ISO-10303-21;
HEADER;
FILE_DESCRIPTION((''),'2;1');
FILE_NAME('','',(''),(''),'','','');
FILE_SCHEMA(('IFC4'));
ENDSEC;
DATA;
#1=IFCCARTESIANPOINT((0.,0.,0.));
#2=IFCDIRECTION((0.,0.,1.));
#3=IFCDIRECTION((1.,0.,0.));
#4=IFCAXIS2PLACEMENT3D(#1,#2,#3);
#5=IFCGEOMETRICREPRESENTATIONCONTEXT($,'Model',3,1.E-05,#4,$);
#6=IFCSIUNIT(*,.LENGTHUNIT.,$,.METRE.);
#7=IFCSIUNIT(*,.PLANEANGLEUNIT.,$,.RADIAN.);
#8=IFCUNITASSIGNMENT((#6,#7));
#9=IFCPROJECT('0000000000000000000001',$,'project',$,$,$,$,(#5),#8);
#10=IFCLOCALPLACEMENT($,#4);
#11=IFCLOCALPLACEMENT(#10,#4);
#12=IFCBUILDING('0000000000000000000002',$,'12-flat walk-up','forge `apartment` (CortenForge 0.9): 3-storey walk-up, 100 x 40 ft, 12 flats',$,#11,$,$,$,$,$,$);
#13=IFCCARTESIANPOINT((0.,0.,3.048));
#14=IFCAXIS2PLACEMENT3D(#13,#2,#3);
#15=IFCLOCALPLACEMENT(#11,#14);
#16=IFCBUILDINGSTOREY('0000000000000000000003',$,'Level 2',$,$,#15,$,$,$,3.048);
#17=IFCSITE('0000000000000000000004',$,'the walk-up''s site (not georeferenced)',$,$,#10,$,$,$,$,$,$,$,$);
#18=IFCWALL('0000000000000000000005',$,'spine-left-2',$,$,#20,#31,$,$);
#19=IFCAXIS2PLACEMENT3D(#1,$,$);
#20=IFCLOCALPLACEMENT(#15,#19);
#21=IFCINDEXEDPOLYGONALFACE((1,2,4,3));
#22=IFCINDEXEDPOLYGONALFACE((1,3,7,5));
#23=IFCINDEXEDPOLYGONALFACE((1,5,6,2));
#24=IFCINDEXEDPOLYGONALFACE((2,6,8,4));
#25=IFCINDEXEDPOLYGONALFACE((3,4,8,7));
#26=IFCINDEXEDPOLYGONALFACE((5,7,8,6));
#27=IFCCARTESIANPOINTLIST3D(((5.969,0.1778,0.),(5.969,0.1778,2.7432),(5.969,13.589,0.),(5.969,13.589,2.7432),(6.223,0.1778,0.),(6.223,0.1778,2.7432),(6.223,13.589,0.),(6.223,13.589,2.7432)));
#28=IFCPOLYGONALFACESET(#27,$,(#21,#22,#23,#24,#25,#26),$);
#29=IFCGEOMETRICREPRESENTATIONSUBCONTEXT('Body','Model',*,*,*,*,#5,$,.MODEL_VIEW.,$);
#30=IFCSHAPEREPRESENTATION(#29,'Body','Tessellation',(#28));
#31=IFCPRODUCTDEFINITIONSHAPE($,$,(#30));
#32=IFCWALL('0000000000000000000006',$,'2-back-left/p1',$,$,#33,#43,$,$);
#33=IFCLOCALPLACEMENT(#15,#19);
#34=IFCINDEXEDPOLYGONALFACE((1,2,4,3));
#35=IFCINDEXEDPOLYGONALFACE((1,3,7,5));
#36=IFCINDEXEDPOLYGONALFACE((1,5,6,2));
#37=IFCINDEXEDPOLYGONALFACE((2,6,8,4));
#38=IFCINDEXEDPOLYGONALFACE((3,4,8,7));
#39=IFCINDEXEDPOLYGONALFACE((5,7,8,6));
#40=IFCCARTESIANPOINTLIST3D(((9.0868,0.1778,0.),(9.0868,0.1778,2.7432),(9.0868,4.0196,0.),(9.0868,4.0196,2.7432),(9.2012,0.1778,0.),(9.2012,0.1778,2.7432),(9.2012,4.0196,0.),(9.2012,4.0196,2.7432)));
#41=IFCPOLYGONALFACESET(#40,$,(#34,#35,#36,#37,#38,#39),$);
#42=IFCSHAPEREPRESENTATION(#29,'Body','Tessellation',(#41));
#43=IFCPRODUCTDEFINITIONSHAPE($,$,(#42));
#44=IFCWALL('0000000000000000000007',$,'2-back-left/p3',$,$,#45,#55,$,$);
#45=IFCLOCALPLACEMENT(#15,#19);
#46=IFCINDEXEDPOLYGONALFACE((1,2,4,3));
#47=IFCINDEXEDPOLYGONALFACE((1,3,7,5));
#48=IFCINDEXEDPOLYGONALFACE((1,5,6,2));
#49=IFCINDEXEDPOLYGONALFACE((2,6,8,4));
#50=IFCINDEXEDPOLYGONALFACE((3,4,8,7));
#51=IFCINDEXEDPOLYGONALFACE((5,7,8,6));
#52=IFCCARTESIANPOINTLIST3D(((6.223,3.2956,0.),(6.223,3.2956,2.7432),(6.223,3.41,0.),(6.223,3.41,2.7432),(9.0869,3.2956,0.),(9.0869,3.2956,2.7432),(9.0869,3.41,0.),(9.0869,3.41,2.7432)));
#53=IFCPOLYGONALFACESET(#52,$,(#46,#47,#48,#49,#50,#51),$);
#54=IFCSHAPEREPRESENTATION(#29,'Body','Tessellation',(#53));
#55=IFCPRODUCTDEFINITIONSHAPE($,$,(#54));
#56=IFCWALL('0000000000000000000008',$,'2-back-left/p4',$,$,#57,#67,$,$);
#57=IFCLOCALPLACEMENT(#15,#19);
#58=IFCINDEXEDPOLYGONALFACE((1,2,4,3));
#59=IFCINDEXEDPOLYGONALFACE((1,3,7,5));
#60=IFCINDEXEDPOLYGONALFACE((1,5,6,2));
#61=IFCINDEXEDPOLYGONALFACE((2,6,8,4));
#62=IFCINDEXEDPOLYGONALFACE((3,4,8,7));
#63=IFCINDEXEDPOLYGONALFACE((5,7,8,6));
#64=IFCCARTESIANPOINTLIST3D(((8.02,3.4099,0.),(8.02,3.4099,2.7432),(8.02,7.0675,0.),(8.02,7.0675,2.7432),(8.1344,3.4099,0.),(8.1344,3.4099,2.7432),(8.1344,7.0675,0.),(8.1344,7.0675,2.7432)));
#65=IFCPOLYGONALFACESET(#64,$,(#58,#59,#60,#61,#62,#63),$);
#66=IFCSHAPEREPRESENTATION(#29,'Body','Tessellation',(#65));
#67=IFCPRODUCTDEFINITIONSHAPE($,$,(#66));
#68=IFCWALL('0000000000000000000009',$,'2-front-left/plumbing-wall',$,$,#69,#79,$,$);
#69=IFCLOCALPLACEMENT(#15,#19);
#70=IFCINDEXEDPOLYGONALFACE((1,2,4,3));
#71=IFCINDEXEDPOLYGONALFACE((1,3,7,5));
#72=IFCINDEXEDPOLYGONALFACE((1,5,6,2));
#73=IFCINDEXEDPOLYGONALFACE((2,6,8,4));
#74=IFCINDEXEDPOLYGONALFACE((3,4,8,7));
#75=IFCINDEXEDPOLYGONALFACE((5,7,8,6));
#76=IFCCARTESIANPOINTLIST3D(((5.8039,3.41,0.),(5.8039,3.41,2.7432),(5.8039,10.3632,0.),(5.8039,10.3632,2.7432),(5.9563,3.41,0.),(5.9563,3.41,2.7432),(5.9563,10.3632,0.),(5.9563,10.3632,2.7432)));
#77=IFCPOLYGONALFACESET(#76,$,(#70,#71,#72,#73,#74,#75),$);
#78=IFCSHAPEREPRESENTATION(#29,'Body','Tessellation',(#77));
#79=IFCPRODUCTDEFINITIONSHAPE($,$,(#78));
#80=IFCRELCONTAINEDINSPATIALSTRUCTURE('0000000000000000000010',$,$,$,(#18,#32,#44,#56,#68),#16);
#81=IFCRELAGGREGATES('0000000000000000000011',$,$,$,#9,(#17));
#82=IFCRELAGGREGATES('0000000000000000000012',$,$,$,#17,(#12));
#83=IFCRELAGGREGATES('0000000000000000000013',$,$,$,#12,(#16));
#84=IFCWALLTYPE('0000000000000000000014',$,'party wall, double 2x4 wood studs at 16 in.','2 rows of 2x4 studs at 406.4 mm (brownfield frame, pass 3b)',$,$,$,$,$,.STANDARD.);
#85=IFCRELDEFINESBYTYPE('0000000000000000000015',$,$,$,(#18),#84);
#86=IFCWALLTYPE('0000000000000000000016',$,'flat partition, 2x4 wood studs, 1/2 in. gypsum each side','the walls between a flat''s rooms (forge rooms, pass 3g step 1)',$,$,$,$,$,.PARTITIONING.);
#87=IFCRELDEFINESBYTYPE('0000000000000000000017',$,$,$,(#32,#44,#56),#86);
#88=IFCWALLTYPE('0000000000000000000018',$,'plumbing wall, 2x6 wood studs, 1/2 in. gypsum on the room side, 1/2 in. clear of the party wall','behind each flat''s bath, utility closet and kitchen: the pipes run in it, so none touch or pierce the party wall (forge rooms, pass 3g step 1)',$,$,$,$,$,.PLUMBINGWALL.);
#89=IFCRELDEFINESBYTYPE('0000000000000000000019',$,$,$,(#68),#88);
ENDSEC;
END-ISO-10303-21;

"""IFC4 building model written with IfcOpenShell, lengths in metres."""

from ifc_helpers import new_model, si_unit, frame, frame_2d, origin, origin_with_axes, place, context, subcontext, project, spatial, rectangle, extrude, type_object, element, save


model = new_model("IFC4")

# Units and contexts
model_context = context("Model", 3, precision=1e-05, world=origin_with_axes())
body_context = subcontext(model_context, "Body", "Model", "MODEL_VIEW")
ifc_project = project(units=[si_unit("LENGTHUNIT", "METRE"), si_unit("PLANEANGLEUNIT", "RADIAN")], contexts=[model_context])

# Site, building, storey
site_placement = place(None, origin_with_axes())
site = spatial("IfcSite", under=ifc_project, at=site_placement, Name="the walk-up's site (not georeferenced)")
building_placement = place(site_placement, origin_with_axes())
building = spatial("IfcBuilding", under=site, at=building_placement, Name="12-flat walk-up", Description="forge `apartment` (CortenForge 0.9): 3-storey walk-up, 100 x 40 ft, 12 flats")
storey_placement = place(building_placement, frame((0.0, 0.0, 3.048), z_axis=(0.0, 0.0, 1.0), x_axis=(1.0, 0.0, 0.0)))
storey = spatial("IfcBuildingStorey", under=building, at=storey_placement, Name="Level 2", Elevation=3.048)

# Walls
wall_type_1 = type_object("IfcWallType", Name="party wall, double 2x4 wood studs at 16 in.", Description="2 rows of 2x4 studs at 406.4 mm (brownfield frame, pass 3b)", PredefinedType="STANDARD")
wall_1_placement = place(storey_placement, frame((5.969, 0.1778, 0.0), z_axis=(0.0, 0.0, 1.0), x_axis=(1.0, 0.0, 0.0)))
element("IfcWall", 1, at=wall_1_placement, inside=storey, type_object=wall_type_1, Name="spine-left-2", context=body_context, shape_type="SweptSolid", body=[
    extrude(rectangle(XDim=0.254, YDim=13.4112, at=frame_2d((0.127, 6.7056))), origin(), (0.0, 0.0, 1.0), 2.7432),
])
wall_type_2 = type_object("IfcWallType", Name="flat partition, 2x4 wood studs, 1/2 in. gypsum each side", Description="the walls between a flat's rooms (forge rooms, pass 3g step 1)", PredefinedType="PARTITIONING")
wall_2_placement = place(storey_placement, frame((9.0869, 0.1778, 0.0), z_axis=(0.0, 0.0, 1.0), x_axis=(1.0, 0.0, 0.0)))
element("IfcWall", 2, at=wall_2_placement, inside=storey, type_object=wall_type_2, Name="2-back-left/p1", context=body_context, shape_type="SweptSolid", body=[
    extrude(rectangle(XDim=0.1143, YDim=3.8417, at=frame_2d((0.0572, 1.9209))), origin(), (0.0, 0.0, 1.0), 2.7432),
])
wall_3_placement = place(storey_placement, frame((6.223, 3.2957, 0.0), z_axis=(0.0, 0.0, 1.0), x_axis=(1.0, 0.0, 0.0)))
element("IfcWall", 3, at=wall_3_placement, inside=storey, type_object=wall_type_2, Name="2-back-left/p3", context=body_context, shape_type="SweptSolid", body=[
    extrude(rectangle(XDim=2.8639, YDim=0.1143, at=frame_2d((1.4319, 0.0571))), origin(), (0.0, 0.0, 1.0), 2.7432),
])
wall_4_placement = place(storey_placement, frame((8.02, 3.4099, 0.0), z_axis=(0.0, 0.0, 1.0), x_axis=(1.0, 0.0, 0.0)))
element("IfcWall", 4, at=wall_4_placement, inside=storey, type_object=wall_type_2, Name="2-back-left/p4", context=body_context, shape_type="SweptSolid", body=[
    extrude(rectangle(XDim=0.1143, YDim=3.6576, at=frame_2d((0.0572, 1.8288))), origin(), (0.0, 0.0, 1.0), 2.7432),
])
wall_type_3 = type_object("IfcWallType", Name="plumbing wall, 2x6 wood studs, 1/2 in. gypsum on the room side, 1/2 in. clear of the party wall", Description="behind each flat's bath, utility closet and kitchen: the pipes run in it, so none touch or pierce the party wall (forge rooms, pass 3g step 1)", PredefinedType="PLUMBINGWALL")
wall_5_placement = place(storey_placement, frame((5.8039, 3.41, 0.0), z_axis=(0.0, 0.0, 1.0), x_axis=(1.0, 0.0, 0.0)))
element("IfcWall", 5, at=wall_5_placement, inside=storey, type_object=wall_type_3, Name="2-front-left/plumbing-wall", context=body_context, shape_type="SweptSolid", body=[
    extrude(rectangle(XDim=0.1524, YDim=6.9533, at=frame_2d((0.0762, 3.4766))), origin(), (0.0, 0.0, 1.0), 2.7432),
])

save(model, "model.ifc")
